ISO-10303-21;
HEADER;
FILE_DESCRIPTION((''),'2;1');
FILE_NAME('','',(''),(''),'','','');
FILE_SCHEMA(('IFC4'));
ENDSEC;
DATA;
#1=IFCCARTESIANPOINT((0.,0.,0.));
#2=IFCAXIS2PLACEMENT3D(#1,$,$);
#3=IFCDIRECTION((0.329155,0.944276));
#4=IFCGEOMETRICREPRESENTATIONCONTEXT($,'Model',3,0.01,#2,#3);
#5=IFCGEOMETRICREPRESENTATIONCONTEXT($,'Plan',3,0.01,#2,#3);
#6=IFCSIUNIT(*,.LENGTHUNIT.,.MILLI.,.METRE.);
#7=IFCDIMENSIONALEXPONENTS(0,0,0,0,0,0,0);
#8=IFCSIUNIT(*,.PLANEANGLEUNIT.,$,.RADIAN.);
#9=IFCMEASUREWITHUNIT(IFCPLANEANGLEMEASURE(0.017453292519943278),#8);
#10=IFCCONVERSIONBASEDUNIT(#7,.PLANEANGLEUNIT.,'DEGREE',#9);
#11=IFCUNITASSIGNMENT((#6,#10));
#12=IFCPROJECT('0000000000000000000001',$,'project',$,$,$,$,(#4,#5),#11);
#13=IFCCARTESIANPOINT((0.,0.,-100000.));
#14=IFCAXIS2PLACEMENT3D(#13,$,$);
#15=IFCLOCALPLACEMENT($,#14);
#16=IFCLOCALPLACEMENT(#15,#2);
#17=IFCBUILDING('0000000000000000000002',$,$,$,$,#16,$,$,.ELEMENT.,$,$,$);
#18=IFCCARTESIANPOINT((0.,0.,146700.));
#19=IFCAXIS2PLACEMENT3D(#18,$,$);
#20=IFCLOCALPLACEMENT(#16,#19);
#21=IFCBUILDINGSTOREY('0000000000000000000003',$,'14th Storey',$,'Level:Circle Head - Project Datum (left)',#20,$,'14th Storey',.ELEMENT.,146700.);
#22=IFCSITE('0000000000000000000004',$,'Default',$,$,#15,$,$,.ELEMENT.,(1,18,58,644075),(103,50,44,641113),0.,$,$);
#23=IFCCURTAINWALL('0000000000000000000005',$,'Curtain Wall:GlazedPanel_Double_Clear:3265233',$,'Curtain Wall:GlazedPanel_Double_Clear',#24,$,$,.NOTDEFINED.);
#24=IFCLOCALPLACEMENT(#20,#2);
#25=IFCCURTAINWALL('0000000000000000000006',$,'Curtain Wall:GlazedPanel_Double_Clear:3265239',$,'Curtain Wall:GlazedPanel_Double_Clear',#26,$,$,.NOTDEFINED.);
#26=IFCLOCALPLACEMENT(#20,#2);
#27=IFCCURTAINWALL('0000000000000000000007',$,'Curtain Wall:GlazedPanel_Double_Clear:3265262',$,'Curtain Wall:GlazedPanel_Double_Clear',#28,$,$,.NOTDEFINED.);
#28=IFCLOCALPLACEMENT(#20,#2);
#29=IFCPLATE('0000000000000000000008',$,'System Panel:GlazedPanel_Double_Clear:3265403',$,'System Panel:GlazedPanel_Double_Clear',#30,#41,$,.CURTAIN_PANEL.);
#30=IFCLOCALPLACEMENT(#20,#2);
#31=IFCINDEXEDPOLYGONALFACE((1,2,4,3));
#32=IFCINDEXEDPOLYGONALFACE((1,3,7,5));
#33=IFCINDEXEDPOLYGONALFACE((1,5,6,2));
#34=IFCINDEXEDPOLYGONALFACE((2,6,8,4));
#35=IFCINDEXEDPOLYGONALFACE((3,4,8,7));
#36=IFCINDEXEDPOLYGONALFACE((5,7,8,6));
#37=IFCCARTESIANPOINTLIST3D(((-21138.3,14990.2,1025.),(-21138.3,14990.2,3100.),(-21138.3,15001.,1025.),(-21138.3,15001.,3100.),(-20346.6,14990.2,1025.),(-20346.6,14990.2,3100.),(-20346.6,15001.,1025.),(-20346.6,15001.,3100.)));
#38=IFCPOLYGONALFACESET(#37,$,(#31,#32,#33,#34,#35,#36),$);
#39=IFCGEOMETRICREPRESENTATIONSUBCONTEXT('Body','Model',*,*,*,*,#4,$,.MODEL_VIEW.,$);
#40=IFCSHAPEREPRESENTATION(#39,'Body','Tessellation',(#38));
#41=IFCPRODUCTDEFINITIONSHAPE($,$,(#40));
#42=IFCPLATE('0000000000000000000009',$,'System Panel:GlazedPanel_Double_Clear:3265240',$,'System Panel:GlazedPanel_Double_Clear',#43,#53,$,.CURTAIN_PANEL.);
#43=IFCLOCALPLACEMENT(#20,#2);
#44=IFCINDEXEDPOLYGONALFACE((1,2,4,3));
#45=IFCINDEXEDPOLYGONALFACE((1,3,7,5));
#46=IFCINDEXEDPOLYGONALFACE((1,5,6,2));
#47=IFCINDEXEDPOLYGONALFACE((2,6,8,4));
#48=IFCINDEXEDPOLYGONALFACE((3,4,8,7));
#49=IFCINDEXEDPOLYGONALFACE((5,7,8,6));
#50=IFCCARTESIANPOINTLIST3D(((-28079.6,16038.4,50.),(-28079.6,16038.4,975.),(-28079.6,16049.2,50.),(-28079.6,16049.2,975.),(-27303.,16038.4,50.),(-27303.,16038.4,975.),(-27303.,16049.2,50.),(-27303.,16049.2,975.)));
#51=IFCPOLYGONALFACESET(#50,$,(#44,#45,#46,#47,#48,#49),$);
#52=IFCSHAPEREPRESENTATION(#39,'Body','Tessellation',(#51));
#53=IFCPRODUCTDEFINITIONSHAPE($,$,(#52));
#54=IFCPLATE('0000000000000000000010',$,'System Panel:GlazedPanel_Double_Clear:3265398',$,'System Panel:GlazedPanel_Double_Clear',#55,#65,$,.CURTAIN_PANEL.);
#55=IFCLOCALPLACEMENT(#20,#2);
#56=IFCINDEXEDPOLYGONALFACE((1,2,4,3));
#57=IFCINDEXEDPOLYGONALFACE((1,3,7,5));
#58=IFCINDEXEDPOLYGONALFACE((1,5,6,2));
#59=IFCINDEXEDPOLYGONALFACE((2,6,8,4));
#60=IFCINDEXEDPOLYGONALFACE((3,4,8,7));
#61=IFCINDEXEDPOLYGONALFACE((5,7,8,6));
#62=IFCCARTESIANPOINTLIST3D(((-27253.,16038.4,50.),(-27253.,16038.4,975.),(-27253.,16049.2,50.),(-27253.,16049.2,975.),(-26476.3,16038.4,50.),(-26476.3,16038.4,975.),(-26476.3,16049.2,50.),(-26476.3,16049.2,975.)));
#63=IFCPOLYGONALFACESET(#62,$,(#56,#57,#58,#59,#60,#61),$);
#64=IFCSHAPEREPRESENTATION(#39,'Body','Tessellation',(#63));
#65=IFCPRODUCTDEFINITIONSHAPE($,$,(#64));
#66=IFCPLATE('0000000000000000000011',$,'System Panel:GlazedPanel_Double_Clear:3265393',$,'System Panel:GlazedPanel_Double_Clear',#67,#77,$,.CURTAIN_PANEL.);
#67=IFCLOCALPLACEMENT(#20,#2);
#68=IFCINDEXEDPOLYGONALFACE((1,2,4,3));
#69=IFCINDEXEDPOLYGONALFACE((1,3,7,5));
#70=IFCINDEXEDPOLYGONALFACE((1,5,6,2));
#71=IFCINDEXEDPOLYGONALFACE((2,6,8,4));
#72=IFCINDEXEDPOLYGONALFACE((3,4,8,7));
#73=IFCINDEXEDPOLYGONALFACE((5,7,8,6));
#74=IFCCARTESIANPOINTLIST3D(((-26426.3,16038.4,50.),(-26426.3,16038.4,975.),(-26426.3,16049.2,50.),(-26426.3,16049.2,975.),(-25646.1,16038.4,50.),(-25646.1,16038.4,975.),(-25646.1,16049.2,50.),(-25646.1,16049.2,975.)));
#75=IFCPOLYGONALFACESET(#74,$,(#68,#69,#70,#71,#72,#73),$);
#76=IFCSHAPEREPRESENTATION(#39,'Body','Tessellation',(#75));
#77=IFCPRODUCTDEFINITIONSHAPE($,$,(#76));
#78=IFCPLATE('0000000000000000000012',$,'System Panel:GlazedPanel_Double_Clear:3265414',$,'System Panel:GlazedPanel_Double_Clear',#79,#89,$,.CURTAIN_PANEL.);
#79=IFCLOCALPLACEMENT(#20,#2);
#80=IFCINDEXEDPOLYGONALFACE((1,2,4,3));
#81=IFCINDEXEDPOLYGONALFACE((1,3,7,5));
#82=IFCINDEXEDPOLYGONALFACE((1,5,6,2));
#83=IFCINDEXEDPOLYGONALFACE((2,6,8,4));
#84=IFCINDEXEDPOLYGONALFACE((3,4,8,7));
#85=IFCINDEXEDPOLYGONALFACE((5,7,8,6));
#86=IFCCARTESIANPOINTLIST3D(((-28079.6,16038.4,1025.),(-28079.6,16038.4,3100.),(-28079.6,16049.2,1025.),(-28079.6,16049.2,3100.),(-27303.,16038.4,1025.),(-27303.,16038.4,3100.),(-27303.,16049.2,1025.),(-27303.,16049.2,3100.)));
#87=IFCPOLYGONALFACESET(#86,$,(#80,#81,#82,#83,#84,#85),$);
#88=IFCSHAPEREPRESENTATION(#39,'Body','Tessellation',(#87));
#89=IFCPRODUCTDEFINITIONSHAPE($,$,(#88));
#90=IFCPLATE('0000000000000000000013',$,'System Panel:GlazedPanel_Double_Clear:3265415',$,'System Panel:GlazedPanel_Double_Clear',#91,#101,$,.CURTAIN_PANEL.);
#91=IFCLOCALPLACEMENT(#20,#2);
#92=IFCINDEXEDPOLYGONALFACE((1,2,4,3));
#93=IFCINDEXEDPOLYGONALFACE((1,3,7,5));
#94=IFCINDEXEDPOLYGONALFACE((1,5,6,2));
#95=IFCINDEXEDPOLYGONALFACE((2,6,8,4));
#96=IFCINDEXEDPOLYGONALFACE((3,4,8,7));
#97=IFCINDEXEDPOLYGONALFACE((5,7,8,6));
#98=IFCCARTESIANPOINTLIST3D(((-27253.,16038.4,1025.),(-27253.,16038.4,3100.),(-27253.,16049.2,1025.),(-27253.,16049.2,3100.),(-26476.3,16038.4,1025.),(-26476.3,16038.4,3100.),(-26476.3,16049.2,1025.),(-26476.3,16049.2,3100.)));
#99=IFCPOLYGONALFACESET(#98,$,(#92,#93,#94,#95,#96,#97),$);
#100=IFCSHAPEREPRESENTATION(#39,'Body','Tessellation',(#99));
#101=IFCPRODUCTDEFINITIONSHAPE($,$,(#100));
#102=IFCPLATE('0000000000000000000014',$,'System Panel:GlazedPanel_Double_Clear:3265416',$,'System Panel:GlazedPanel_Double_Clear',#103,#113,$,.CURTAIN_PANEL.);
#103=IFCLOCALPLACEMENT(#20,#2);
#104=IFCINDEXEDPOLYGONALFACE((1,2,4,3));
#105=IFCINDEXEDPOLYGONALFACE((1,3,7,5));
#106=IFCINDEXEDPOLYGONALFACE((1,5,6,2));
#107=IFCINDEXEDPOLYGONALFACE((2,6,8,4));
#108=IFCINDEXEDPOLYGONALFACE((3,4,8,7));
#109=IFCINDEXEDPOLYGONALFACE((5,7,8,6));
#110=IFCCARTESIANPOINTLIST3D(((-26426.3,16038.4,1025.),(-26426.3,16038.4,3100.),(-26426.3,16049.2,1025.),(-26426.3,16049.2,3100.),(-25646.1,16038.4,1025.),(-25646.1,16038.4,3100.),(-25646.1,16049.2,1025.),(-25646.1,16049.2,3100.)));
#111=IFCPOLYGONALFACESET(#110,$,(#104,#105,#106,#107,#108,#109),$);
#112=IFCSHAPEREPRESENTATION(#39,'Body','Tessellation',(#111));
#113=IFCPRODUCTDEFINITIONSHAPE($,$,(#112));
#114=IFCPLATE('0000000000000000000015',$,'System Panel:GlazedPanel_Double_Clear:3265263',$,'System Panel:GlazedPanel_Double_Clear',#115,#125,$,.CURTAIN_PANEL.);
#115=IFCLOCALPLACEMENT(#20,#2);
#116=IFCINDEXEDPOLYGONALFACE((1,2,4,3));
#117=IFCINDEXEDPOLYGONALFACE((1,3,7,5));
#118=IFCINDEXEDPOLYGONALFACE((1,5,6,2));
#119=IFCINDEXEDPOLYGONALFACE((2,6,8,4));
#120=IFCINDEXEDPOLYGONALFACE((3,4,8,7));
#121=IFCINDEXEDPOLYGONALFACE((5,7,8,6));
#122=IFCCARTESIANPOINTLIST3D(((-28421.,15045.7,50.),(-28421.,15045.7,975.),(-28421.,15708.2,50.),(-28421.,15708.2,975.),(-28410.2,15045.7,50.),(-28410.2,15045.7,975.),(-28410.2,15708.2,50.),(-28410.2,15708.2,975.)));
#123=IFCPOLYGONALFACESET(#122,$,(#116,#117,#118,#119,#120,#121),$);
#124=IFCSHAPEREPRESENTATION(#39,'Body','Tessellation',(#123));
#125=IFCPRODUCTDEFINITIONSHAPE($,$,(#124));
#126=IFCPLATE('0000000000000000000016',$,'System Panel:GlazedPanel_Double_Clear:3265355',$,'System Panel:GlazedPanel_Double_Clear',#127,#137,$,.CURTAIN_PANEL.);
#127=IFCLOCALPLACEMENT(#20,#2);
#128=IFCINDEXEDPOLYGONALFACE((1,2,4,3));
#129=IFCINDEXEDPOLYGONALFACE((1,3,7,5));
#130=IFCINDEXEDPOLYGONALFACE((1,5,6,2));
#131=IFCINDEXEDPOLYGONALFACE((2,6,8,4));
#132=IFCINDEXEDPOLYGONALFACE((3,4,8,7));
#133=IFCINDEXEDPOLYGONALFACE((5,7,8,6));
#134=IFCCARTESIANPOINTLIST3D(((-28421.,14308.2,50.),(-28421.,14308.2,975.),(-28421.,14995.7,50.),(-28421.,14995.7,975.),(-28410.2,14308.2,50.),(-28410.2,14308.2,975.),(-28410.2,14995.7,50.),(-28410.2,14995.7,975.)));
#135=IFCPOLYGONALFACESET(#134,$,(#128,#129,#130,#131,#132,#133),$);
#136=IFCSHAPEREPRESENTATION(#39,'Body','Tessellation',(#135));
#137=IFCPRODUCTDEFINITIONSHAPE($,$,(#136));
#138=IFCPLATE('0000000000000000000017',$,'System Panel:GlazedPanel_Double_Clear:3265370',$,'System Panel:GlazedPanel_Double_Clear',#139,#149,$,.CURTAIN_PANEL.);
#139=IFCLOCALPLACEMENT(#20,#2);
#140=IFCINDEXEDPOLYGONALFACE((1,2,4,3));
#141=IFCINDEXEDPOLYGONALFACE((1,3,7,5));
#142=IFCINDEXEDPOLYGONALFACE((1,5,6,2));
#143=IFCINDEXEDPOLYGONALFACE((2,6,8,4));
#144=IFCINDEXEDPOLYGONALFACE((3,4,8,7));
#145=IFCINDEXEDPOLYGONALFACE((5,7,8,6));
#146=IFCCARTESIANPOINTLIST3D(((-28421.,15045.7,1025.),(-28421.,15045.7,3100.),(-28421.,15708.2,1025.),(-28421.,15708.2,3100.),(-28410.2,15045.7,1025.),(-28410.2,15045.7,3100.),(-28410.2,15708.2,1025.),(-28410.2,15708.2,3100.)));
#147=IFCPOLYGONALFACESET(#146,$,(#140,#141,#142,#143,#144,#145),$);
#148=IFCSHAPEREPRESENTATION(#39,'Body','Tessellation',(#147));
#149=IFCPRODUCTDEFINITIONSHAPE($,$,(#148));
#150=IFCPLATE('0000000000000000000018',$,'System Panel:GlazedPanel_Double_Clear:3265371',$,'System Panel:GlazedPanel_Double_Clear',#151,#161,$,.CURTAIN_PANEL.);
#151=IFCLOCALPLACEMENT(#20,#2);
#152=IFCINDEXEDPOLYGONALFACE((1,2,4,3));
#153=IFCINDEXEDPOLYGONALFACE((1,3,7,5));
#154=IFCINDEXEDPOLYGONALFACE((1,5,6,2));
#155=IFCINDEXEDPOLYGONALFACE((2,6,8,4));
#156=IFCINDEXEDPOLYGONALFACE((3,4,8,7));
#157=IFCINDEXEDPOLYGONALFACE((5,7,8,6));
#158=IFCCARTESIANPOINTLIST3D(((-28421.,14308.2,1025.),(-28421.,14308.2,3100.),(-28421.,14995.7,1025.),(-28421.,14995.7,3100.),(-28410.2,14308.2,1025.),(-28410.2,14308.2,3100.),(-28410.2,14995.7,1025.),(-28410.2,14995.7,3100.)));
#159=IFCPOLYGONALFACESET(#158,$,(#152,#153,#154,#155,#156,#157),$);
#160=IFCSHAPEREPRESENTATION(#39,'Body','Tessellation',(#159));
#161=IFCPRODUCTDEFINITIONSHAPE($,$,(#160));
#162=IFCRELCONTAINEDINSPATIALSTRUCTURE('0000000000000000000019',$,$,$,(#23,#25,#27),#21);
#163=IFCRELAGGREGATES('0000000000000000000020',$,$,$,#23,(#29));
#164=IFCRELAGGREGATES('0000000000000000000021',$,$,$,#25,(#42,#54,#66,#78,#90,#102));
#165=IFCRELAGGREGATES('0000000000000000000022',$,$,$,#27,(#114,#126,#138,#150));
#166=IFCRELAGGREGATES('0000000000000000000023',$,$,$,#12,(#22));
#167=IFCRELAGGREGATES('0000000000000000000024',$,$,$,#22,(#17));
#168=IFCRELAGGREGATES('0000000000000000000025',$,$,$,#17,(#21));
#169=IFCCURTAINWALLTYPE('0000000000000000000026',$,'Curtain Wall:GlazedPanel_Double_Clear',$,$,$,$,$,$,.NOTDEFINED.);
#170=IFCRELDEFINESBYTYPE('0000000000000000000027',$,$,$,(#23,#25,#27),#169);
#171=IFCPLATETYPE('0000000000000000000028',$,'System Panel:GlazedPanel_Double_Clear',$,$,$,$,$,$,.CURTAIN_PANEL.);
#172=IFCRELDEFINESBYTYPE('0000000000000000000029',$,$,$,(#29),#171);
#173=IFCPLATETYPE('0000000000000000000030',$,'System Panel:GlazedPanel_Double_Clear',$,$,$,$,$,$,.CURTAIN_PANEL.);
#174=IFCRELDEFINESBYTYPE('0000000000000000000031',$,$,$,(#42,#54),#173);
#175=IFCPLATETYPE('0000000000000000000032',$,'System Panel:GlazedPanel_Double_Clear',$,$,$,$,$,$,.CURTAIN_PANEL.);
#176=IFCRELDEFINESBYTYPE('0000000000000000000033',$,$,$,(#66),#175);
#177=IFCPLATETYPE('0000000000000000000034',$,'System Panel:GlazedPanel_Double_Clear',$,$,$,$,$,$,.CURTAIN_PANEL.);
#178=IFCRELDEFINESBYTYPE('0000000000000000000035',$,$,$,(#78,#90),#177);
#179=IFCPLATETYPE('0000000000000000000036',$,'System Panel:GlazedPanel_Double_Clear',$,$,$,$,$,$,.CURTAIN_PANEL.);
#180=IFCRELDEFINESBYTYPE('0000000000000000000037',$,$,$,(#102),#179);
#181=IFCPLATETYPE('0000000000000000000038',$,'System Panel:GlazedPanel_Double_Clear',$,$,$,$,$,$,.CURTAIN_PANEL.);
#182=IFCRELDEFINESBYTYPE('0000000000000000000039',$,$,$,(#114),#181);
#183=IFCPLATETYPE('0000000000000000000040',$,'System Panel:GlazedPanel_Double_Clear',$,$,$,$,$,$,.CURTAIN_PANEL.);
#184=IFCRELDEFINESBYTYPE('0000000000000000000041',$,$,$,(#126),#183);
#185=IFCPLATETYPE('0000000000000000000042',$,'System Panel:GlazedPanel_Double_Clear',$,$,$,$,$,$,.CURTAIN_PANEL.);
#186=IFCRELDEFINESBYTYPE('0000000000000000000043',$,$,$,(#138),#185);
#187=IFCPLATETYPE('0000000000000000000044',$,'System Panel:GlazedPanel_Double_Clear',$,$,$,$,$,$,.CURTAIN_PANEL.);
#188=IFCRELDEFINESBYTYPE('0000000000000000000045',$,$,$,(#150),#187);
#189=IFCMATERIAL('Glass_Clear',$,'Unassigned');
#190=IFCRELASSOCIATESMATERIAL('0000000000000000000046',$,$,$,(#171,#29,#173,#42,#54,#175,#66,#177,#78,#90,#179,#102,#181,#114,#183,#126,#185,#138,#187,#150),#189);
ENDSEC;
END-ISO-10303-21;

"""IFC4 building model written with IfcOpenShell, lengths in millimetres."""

from ifc_helpers import new_model, entity, si_unit, converted_unit, direction, frame, origin, place, context, subcontext, project, spatial, indexed_curve, outline, extrude, source, transform, mapped, material, type_object, type_shapes, element, aggregate, save


model = new_model("IFC4")

# Units and contexts
model_context = context("Model", 3, precision=0.01, world=origin(), true_north=direction((0.329155, 0.944276)))
plan_context = context("Plan", 3, precision=0.01, world=origin(), true_north=direction((0.329155, 0.944276)))
body_context = subcontext(model_context, "Body", "Model", "MODEL_VIEW")
ifc_project = project(units=[si_unit("LENGTHUNIT", "METRE", prefix="MILLI"), converted_unit("PLANEANGLEUNIT", "DEGREE", entity("IfcPlaneAngleMeasure", 0.017453292519943278), si_unit("PLANEANGLEUNIT", "RADIAN"), dimensions=[0, 0, 0, 0, 0, 0, 0])], contexts=[model_context, plan_context])

# Site, building, storey
site_placement = place(None, frame((0.0, 0.0, -100000.0)))
site = spatial("IfcSite", under=ifc_project, at=site_placement, Name="Default", CompositionType="ELEMENT", RefLatitude=(1, 18, 58, 644075), RefLongitude=(103, 50, 44, 641113), RefElevation=0.0)
building_placement = place(site_placement, origin())
building = spatial("IfcBuilding", under=site, at=building_placement, CompositionType="ELEMENT")
storey_placement = place(building_placement, frame((0.0, 0.0, 146700.0)))
storey = spatial("IfcBuildingStorey", under=building, at=storey_placement, Name="14th Storey", ObjectType="Level:Circle Head - Project Datum (left)", LongName="14th Storey", CompositionType="ELEMENT", Elevation=146700.0)

# Curtain wall
curtain_wall_type = type_object("IfcCurtainWallType", Name="Curtain Wall:GlazedPanel_Double_Clear", PredefinedType="NOTDEFINED")
curtain_wall_1_placement = place(storey_placement, frame((0.0, 0.0, -146700.0)))
curtain_wall_1 = element("IfcCurtainWall", 1, at=curtain_wall_1_placement, inside=storey, type_object=curtain_wall_type, Name="Curtain Wall:GlazedPanel_Double_Clear:3265233", ObjectType="Curtain Wall:GlazedPanel_Double_Clear", PredefinedType="NOTDEFINED")

# Curtain wall
curtain_wall_2_placement = place(storey_placement, frame((0.0, 0.0, -146700.0)))
curtain_wall_2 = element("IfcCurtainWall", 2, at=curtain_wall_2_placement, inside=storey, type_object=curtain_wall_type, Name="Curtain Wall:GlazedPanel_Double_Clear:3265239", ObjectType="Curtain Wall:GlazedPanel_Double_Clear", PredefinedType="NOTDEFINED")

# Curtain wall
curtain_wall_3_placement = place(storey_placement, frame((0.0, 0.0, -146700.0)))
curtain_wall_3 = element("IfcCurtainWall", 3, at=curtain_wall_3_placement, inside=storey, type_object=curtain_wall_type, Name="Curtain Wall:GlazedPanel_Double_Clear:3265262", ObjectType="Curtain Wall:GlazedPanel_Double_Clear", PredefinedType="NOTDEFINED")

# Plates
ifc_material_1 = material(Name="Glass_Clear", Category="Unassigned")
plate_type_1 = type_object("IfcPlateType", Name="System Panel:GlazedPanel_Double_Clear", PredefinedType="CURTAIN_PANEL", material=ifc_material_1)
shared_shape_1 = source(origin(), body_context, "Body", "SweptSolid", [
    extrude(outline(indexed_curve([(-5.4, -395.8), (5.4, -395.8), (5.4, 395.8), (-5.4, 395.8), (-5.4, -395.8)], self_intersect=False)), frame((395.8, 5.4, 0.0), z_axis=(0.0, 0.0, 1.0), x_axis=(0.0, 1.0, 0.0)), (0.0, 0.0, 1.0), 2075.0),
])
type_shapes(plate_type_1, [shared_shape_1])
plate_1_placement = place(curtain_wall_1_placement, frame((-21138.3, 14990.2, 147725.0)))
plate_1 = element("IfcPlate", 4, at=plate_1_placement, type_object=plate_type_1, material=ifc_material_1, Name="System Panel:GlazedPanel_Double_Clear:3265403", ObjectType="System Panel:GlazedPanel_Double_Clear", PredefinedType="CURTAIN_PANEL", context=body_context, shape_type="MappedRepresentation", body=[
    mapped(shared_shape_1, transform((0.0, 0.0, 0.0), scale=1.0)),
])
aggregate(curtain_wall_1, [plate_1])
plate_type_2 = type_object("IfcPlateType", Name="System Panel:GlazedPanel_Double_Clear", PredefinedType="CURTAIN_PANEL", material=ifc_material_1)
shared_shape_2 = source(origin(), body_context, "Body", "SweptSolid", [
    extrude(outline(indexed_curve([(-5.4, -388.3), (5.4, -388.3), (5.4, 388.3), (-5.4, 388.3), (-5.4, -388.3)], self_intersect=False)), frame((388.3, 5.4, 0.0), z_axis=(0.0, 0.0, 1.0), x_axis=(0.0, 1.0, 0.0)), (0.0, 0.0, 1.0), 925.0),
])
type_shapes(plate_type_2, [shared_shape_2])
plate_2_placement = place(curtain_wall_2_placement, frame((-28079.6, 16038.4, 146750.0)))
plate_2 = element("IfcPlate", 5, at=plate_2_placement, type_object=plate_type_2, material=ifc_material_1, Name="System Panel:GlazedPanel_Double_Clear:3265240", ObjectType="System Panel:GlazedPanel_Double_Clear", PredefinedType="CURTAIN_PANEL", context=body_context, shape_type="MappedRepresentation", body=[
    mapped(shared_shape_2, transform((0.0, 0.0, 0.0), scale=1.0)),
])
plate_3_placement = place(curtain_wall_2_placement, frame((-27253.0, 16038.4, 146750.0)))
plate_3 = element("IfcPlate", 6, at=plate_3_placement, type_object=plate_type_2, material=ifc_material_1, Name="System Panel:GlazedPanel_Double_Clear:3265398", ObjectType="System Panel:GlazedPanel_Double_Clear", PredefinedType="CURTAIN_PANEL", context=body_context, shape_type="MappedRepresentation", body=[
    mapped(shared_shape_2, transform((0.0, 0.0, 0.0), scale=1.0)),
])
plate_type_3 = type_object("IfcPlateType", Name="System Panel:GlazedPanel_Double_Clear", PredefinedType="CURTAIN_PANEL", material=ifc_material_1)
shared_shape_3 = source(origin(), body_context, "Body", "SweptSolid", [
    extrude(outline(indexed_curve([(-5.4, -390.1), (5.4, -390.1), (5.4, 390.1), (-5.4, 390.1), (-5.4, -390.1)], self_intersect=False)), frame((390.1, 5.4, 0.0), z_axis=(0.0, 0.0, 1.0), x_axis=(0.0, 1.0, 0.0)), (0.0, 0.0, 1.0), 925.0),
])
type_shapes(plate_type_3, [shared_shape_3])
plate_4_placement = place(curtain_wall_2_placement, frame((-26426.3, 16038.4, 146750.0)))
plate_4 = element("IfcPlate", 7, at=plate_4_placement, type_object=plate_type_3, material=ifc_material_1, Name="System Panel:GlazedPanel_Double_Clear:3265393", ObjectType="System Panel:GlazedPanel_Double_Clear", PredefinedType="CURTAIN_PANEL", context=body_context, shape_type="MappedRepresentation", body=[
    mapped(shared_shape_3, transform((0.0, 0.0, 0.0), scale=1.0)),
])
plate_type_4 = type_object("IfcPlateType", Name="System Panel:GlazedPanel_Double_Clear", PredefinedType="CURTAIN_PANEL", material=ifc_material_1)
shared_shape_4 = source(origin(), body_context, "Body", "SweptSolid", [
    extrude(outline(indexed_curve([(-5.4, -388.3), (5.4, -388.3), (5.4, 388.3), (-5.4, 388.3), (-5.4, -388.3)], self_intersect=False)), frame((388.3, 5.4, 0.0), z_axis=(0.0, 0.0, 1.0), x_axis=(0.0, 1.0, 0.0)), (0.0, 0.0, 1.0), 2075.0),
])
type_shapes(plate_type_4, [shared_shape_4])
plate_5_placement = place(curtain_wall_2_placement, frame((-28079.6, 16038.4, 147725.0)))
plate_5 = element("IfcPlate", 8, at=plate_5_placement, type_object=plate_type_4, material=ifc_material_1, Name="System Panel:GlazedPanel_Double_Clear:3265414", ObjectType="System Panel:GlazedPanel_Double_Clear", PredefinedType="CURTAIN_PANEL", context=body_context, shape_type="MappedRepresentation", body=[
    mapped(shared_shape_4, transform((0.0, 0.0, 0.0), scale=1.0)),
])
plate_6_placement = place(curtain_wall_2_placement, frame((-27253.0, 16038.4, 147725.0)))
plate_6 = element("IfcPlate", 9, at=plate_6_placement, type_object=plate_type_4, material=ifc_material_1, Name="System Panel:GlazedPanel_Double_Clear:3265415", ObjectType="System Panel:GlazedPanel_Double_Clear", PredefinedType="CURTAIN_PANEL", context=body_context, shape_type="MappedRepresentation", body=[
    mapped(shared_shape_4, transform((0.0, 0.0, 0.0), scale=1.0)),
])
plate_type_5 = type_object("IfcPlateType", Name="System Panel:GlazedPanel_Double_Clear", PredefinedType="CURTAIN_PANEL", material=ifc_material_1)
shared_shape_5 = source(origin(), body_context, "Body", "SweptSolid", [
    extrude(outline(indexed_curve([(-5.4, -390.1), (5.4, -390.1), (5.4, 390.1), (-5.4, 390.1), (-5.4, -390.1)], self_intersect=False)), frame((390.1, 5.4, 0.0), z_axis=(0.0, 0.0, 1.0), x_axis=(0.0, 1.0, 0.0)), (0.0, 0.0, 1.0), 2075.0),
])
type_shapes(plate_type_5, [shared_shape_5])
plate_7_placement = place(curtain_wall_2_placement, frame((-26426.3, 16038.4, 147725.0)))
plate_7 = element("IfcPlate", 10, at=plate_7_placement, type_object=plate_type_5, material=ifc_material_1, Name="System Panel:GlazedPanel_Double_Clear:3265416", ObjectType="System Panel:GlazedPanel_Double_Clear", PredefinedType="CURTAIN_PANEL", context=body_context, shape_type="MappedRepresentation", body=[
    mapped(shared_shape_5, transform((0.0, 0.0, 0.0), scale=1.0)),
])
aggregate(curtain_wall_2, [plate_2, plate_3, plate_4, plate_5, plate_6, plate_7])
plate_type_6 = type_object("IfcPlateType", Name="System Panel:GlazedPanel_Double_Clear", PredefinedType="CURTAIN_PANEL", material=ifc_material_1)
shared_shape_6 = source(origin(), body_context, "Body", "SweptSolid", [
    extrude(outline(indexed_curve([(-5.4, -331.3), (5.4, -331.3), (5.4, 331.3), (-5.4, 331.3), (-5.4, -331.3)], self_intersect=False)), frame((331.3, 5.4, 0.0), z_axis=(0.0, 0.0, 1.0), x_axis=(0.0, 1.0, 0.0)), (0.0, 0.0, 1.0), 925.0),
])
type_shapes(plate_type_6, [shared_shape_6])
plate_8_placement = place(curtain_wall_3_placement, frame((-28421.0, 15708.2, 146750.0), z_axis=(0.0, 0.0, 1.0), x_axis=(0.0, -1.0, 0.0)))
plate_8 = element("IfcPlate", 11, at=plate_8_placement, type_object=plate_type_6, material=ifc_material_1, Name="System Panel:GlazedPanel_Double_Clear:3265263", ObjectType="System Panel:GlazedPanel_Double_Clear", PredefinedType="CURTAIN_PANEL", context=body_context, shape_type="MappedRepresentation", body=[
    mapped(shared_shape_6, transform((0.0, 0.0, 0.0), scale=1.0)),
])
plate_type_7 = type_object("IfcPlateType", Name="System Panel:GlazedPanel_Double_Clear", PredefinedType="CURTAIN_PANEL", material=ifc_material_1)
shared_shape_7 = source(origin(), body_context, "Body", "SweptSolid", [
    extrude(outline(indexed_curve([(-5.4, -343.7), (5.4, -343.7), (5.4, 343.7), (-5.4, 343.7), (-5.4, -343.7)], self_intersect=False)), frame((343.7, 5.4, 0.0), z_axis=(0.0, 0.0, 1.0), x_axis=(0.0, 1.0, 0.0)), (0.0, 0.0, 1.0), 925.0),
])
type_shapes(plate_type_7, [shared_shape_7])
plate_9_placement = place(curtain_wall_3_placement, frame((-28421.0, 14995.7, 146750.0), z_axis=(0.0, 0.0, 1.0), x_axis=(0.0, -1.0, 0.0)))
plate_9 = element("IfcPlate", 12, at=plate_9_placement, type_object=plate_type_7, material=ifc_material_1, Name="System Panel:GlazedPanel_Double_Clear:3265355", ObjectType="System Panel:GlazedPanel_Double_Clear", PredefinedType="CURTAIN_PANEL", context=body_context, shape_type="MappedRepresentation", body=[
    mapped(shared_shape_7, transform((0.0, 0.0, 0.0), scale=1.0)),
])
plate_type_8 = type_object("IfcPlateType", Name="System Panel:GlazedPanel_Double_Clear", PredefinedType="CURTAIN_PANEL", material=ifc_material_1)
shared_shape_8 = source(origin(), body_context, "Body", "SweptSolid", [
    extrude(outline(indexed_curve([(-5.4, -331.3), (5.4, -331.3), (5.4, 331.3), (-5.4, 331.3), (-5.4, -331.3)], self_intersect=False)), frame((331.3, 5.4, 0.0), z_axis=(0.0, 0.0, 1.0), x_axis=(0.0, 1.0, 0.0)), (0.0, 0.0, 1.0), 2075.0),
])
type_shapes(plate_type_8, [shared_shape_8])
plate_10_placement = place(curtain_wall_3_placement, frame((-28421.0, 15708.2, 147725.0), z_axis=(0.0, 0.0, 1.0), x_axis=(0.0, -1.0, 0.0)))
plate_10 = element("IfcPlate", 13, at=plate_10_placement, type_object=plate_type_8, material=ifc_material_1, Name="System Panel:GlazedPanel_Double_Clear:3265370", ObjectType="System Panel:GlazedPanel_Double_Clear", PredefinedType="CURTAIN_PANEL", context=body_context, shape_type="MappedRepresentation", body=[
    mapped(shared_shape_8, transform((0.0, 0.0, 0.0), scale=1.0)),
])
plate_type_9 = type_object("IfcPlateType", Name="System Panel:GlazedPanel_Double_Clear", PredefinedType="CURTAIN_PANEL", material=ifc_material_1)
shared_shape_9 = source(origin(), body_context, "Body", "SweptSolid", [
    extrude(outline(indexed_curve([(-5.4, -343.7), (5.4, -343.7), (5.4, 343.7), (-5.4, 343.7), (-5.4, -343.7)], self_intersect=False)), frame((343.7, 5.4, 0.0), z_axis=(0.0, 0.0, 1.0), x_axis=(0.0, 1.0, 0.0)), (0.0, 0.0, 1.0), 2075.0),
])
type_shapes(plate_type_9, [shared_shape_9])
plate_11_placement = place(curtain_wall_3_placement, frame((-28421.0, 14995.7, 147725.0), z_axis=(0.0, 0.0, 1.0), x_axis=(0.0, -1.0, 0.0)))
plate_11 = element("IfcPlate", 14, at=plate_11_placement, type_object=plate_type_9, material=ifc_material_1, Name="System Panel:GlazedPanel_Double_Clear:3265371", ObjectType="System Panel:GlazedPanel_Double_Clear", PredefinedType="CURTAIN_PANEL", context=body_context, shape_type="MappedRepresentation", body=[
    mapped(shared_shape_9, transform((0.0, 0.0, 0.0), scale=1.0)),
])
aggregate(curtain_wall_3, [plate_8, plate_9, plate_10, plate_11])

save(model, "model.ifc")
